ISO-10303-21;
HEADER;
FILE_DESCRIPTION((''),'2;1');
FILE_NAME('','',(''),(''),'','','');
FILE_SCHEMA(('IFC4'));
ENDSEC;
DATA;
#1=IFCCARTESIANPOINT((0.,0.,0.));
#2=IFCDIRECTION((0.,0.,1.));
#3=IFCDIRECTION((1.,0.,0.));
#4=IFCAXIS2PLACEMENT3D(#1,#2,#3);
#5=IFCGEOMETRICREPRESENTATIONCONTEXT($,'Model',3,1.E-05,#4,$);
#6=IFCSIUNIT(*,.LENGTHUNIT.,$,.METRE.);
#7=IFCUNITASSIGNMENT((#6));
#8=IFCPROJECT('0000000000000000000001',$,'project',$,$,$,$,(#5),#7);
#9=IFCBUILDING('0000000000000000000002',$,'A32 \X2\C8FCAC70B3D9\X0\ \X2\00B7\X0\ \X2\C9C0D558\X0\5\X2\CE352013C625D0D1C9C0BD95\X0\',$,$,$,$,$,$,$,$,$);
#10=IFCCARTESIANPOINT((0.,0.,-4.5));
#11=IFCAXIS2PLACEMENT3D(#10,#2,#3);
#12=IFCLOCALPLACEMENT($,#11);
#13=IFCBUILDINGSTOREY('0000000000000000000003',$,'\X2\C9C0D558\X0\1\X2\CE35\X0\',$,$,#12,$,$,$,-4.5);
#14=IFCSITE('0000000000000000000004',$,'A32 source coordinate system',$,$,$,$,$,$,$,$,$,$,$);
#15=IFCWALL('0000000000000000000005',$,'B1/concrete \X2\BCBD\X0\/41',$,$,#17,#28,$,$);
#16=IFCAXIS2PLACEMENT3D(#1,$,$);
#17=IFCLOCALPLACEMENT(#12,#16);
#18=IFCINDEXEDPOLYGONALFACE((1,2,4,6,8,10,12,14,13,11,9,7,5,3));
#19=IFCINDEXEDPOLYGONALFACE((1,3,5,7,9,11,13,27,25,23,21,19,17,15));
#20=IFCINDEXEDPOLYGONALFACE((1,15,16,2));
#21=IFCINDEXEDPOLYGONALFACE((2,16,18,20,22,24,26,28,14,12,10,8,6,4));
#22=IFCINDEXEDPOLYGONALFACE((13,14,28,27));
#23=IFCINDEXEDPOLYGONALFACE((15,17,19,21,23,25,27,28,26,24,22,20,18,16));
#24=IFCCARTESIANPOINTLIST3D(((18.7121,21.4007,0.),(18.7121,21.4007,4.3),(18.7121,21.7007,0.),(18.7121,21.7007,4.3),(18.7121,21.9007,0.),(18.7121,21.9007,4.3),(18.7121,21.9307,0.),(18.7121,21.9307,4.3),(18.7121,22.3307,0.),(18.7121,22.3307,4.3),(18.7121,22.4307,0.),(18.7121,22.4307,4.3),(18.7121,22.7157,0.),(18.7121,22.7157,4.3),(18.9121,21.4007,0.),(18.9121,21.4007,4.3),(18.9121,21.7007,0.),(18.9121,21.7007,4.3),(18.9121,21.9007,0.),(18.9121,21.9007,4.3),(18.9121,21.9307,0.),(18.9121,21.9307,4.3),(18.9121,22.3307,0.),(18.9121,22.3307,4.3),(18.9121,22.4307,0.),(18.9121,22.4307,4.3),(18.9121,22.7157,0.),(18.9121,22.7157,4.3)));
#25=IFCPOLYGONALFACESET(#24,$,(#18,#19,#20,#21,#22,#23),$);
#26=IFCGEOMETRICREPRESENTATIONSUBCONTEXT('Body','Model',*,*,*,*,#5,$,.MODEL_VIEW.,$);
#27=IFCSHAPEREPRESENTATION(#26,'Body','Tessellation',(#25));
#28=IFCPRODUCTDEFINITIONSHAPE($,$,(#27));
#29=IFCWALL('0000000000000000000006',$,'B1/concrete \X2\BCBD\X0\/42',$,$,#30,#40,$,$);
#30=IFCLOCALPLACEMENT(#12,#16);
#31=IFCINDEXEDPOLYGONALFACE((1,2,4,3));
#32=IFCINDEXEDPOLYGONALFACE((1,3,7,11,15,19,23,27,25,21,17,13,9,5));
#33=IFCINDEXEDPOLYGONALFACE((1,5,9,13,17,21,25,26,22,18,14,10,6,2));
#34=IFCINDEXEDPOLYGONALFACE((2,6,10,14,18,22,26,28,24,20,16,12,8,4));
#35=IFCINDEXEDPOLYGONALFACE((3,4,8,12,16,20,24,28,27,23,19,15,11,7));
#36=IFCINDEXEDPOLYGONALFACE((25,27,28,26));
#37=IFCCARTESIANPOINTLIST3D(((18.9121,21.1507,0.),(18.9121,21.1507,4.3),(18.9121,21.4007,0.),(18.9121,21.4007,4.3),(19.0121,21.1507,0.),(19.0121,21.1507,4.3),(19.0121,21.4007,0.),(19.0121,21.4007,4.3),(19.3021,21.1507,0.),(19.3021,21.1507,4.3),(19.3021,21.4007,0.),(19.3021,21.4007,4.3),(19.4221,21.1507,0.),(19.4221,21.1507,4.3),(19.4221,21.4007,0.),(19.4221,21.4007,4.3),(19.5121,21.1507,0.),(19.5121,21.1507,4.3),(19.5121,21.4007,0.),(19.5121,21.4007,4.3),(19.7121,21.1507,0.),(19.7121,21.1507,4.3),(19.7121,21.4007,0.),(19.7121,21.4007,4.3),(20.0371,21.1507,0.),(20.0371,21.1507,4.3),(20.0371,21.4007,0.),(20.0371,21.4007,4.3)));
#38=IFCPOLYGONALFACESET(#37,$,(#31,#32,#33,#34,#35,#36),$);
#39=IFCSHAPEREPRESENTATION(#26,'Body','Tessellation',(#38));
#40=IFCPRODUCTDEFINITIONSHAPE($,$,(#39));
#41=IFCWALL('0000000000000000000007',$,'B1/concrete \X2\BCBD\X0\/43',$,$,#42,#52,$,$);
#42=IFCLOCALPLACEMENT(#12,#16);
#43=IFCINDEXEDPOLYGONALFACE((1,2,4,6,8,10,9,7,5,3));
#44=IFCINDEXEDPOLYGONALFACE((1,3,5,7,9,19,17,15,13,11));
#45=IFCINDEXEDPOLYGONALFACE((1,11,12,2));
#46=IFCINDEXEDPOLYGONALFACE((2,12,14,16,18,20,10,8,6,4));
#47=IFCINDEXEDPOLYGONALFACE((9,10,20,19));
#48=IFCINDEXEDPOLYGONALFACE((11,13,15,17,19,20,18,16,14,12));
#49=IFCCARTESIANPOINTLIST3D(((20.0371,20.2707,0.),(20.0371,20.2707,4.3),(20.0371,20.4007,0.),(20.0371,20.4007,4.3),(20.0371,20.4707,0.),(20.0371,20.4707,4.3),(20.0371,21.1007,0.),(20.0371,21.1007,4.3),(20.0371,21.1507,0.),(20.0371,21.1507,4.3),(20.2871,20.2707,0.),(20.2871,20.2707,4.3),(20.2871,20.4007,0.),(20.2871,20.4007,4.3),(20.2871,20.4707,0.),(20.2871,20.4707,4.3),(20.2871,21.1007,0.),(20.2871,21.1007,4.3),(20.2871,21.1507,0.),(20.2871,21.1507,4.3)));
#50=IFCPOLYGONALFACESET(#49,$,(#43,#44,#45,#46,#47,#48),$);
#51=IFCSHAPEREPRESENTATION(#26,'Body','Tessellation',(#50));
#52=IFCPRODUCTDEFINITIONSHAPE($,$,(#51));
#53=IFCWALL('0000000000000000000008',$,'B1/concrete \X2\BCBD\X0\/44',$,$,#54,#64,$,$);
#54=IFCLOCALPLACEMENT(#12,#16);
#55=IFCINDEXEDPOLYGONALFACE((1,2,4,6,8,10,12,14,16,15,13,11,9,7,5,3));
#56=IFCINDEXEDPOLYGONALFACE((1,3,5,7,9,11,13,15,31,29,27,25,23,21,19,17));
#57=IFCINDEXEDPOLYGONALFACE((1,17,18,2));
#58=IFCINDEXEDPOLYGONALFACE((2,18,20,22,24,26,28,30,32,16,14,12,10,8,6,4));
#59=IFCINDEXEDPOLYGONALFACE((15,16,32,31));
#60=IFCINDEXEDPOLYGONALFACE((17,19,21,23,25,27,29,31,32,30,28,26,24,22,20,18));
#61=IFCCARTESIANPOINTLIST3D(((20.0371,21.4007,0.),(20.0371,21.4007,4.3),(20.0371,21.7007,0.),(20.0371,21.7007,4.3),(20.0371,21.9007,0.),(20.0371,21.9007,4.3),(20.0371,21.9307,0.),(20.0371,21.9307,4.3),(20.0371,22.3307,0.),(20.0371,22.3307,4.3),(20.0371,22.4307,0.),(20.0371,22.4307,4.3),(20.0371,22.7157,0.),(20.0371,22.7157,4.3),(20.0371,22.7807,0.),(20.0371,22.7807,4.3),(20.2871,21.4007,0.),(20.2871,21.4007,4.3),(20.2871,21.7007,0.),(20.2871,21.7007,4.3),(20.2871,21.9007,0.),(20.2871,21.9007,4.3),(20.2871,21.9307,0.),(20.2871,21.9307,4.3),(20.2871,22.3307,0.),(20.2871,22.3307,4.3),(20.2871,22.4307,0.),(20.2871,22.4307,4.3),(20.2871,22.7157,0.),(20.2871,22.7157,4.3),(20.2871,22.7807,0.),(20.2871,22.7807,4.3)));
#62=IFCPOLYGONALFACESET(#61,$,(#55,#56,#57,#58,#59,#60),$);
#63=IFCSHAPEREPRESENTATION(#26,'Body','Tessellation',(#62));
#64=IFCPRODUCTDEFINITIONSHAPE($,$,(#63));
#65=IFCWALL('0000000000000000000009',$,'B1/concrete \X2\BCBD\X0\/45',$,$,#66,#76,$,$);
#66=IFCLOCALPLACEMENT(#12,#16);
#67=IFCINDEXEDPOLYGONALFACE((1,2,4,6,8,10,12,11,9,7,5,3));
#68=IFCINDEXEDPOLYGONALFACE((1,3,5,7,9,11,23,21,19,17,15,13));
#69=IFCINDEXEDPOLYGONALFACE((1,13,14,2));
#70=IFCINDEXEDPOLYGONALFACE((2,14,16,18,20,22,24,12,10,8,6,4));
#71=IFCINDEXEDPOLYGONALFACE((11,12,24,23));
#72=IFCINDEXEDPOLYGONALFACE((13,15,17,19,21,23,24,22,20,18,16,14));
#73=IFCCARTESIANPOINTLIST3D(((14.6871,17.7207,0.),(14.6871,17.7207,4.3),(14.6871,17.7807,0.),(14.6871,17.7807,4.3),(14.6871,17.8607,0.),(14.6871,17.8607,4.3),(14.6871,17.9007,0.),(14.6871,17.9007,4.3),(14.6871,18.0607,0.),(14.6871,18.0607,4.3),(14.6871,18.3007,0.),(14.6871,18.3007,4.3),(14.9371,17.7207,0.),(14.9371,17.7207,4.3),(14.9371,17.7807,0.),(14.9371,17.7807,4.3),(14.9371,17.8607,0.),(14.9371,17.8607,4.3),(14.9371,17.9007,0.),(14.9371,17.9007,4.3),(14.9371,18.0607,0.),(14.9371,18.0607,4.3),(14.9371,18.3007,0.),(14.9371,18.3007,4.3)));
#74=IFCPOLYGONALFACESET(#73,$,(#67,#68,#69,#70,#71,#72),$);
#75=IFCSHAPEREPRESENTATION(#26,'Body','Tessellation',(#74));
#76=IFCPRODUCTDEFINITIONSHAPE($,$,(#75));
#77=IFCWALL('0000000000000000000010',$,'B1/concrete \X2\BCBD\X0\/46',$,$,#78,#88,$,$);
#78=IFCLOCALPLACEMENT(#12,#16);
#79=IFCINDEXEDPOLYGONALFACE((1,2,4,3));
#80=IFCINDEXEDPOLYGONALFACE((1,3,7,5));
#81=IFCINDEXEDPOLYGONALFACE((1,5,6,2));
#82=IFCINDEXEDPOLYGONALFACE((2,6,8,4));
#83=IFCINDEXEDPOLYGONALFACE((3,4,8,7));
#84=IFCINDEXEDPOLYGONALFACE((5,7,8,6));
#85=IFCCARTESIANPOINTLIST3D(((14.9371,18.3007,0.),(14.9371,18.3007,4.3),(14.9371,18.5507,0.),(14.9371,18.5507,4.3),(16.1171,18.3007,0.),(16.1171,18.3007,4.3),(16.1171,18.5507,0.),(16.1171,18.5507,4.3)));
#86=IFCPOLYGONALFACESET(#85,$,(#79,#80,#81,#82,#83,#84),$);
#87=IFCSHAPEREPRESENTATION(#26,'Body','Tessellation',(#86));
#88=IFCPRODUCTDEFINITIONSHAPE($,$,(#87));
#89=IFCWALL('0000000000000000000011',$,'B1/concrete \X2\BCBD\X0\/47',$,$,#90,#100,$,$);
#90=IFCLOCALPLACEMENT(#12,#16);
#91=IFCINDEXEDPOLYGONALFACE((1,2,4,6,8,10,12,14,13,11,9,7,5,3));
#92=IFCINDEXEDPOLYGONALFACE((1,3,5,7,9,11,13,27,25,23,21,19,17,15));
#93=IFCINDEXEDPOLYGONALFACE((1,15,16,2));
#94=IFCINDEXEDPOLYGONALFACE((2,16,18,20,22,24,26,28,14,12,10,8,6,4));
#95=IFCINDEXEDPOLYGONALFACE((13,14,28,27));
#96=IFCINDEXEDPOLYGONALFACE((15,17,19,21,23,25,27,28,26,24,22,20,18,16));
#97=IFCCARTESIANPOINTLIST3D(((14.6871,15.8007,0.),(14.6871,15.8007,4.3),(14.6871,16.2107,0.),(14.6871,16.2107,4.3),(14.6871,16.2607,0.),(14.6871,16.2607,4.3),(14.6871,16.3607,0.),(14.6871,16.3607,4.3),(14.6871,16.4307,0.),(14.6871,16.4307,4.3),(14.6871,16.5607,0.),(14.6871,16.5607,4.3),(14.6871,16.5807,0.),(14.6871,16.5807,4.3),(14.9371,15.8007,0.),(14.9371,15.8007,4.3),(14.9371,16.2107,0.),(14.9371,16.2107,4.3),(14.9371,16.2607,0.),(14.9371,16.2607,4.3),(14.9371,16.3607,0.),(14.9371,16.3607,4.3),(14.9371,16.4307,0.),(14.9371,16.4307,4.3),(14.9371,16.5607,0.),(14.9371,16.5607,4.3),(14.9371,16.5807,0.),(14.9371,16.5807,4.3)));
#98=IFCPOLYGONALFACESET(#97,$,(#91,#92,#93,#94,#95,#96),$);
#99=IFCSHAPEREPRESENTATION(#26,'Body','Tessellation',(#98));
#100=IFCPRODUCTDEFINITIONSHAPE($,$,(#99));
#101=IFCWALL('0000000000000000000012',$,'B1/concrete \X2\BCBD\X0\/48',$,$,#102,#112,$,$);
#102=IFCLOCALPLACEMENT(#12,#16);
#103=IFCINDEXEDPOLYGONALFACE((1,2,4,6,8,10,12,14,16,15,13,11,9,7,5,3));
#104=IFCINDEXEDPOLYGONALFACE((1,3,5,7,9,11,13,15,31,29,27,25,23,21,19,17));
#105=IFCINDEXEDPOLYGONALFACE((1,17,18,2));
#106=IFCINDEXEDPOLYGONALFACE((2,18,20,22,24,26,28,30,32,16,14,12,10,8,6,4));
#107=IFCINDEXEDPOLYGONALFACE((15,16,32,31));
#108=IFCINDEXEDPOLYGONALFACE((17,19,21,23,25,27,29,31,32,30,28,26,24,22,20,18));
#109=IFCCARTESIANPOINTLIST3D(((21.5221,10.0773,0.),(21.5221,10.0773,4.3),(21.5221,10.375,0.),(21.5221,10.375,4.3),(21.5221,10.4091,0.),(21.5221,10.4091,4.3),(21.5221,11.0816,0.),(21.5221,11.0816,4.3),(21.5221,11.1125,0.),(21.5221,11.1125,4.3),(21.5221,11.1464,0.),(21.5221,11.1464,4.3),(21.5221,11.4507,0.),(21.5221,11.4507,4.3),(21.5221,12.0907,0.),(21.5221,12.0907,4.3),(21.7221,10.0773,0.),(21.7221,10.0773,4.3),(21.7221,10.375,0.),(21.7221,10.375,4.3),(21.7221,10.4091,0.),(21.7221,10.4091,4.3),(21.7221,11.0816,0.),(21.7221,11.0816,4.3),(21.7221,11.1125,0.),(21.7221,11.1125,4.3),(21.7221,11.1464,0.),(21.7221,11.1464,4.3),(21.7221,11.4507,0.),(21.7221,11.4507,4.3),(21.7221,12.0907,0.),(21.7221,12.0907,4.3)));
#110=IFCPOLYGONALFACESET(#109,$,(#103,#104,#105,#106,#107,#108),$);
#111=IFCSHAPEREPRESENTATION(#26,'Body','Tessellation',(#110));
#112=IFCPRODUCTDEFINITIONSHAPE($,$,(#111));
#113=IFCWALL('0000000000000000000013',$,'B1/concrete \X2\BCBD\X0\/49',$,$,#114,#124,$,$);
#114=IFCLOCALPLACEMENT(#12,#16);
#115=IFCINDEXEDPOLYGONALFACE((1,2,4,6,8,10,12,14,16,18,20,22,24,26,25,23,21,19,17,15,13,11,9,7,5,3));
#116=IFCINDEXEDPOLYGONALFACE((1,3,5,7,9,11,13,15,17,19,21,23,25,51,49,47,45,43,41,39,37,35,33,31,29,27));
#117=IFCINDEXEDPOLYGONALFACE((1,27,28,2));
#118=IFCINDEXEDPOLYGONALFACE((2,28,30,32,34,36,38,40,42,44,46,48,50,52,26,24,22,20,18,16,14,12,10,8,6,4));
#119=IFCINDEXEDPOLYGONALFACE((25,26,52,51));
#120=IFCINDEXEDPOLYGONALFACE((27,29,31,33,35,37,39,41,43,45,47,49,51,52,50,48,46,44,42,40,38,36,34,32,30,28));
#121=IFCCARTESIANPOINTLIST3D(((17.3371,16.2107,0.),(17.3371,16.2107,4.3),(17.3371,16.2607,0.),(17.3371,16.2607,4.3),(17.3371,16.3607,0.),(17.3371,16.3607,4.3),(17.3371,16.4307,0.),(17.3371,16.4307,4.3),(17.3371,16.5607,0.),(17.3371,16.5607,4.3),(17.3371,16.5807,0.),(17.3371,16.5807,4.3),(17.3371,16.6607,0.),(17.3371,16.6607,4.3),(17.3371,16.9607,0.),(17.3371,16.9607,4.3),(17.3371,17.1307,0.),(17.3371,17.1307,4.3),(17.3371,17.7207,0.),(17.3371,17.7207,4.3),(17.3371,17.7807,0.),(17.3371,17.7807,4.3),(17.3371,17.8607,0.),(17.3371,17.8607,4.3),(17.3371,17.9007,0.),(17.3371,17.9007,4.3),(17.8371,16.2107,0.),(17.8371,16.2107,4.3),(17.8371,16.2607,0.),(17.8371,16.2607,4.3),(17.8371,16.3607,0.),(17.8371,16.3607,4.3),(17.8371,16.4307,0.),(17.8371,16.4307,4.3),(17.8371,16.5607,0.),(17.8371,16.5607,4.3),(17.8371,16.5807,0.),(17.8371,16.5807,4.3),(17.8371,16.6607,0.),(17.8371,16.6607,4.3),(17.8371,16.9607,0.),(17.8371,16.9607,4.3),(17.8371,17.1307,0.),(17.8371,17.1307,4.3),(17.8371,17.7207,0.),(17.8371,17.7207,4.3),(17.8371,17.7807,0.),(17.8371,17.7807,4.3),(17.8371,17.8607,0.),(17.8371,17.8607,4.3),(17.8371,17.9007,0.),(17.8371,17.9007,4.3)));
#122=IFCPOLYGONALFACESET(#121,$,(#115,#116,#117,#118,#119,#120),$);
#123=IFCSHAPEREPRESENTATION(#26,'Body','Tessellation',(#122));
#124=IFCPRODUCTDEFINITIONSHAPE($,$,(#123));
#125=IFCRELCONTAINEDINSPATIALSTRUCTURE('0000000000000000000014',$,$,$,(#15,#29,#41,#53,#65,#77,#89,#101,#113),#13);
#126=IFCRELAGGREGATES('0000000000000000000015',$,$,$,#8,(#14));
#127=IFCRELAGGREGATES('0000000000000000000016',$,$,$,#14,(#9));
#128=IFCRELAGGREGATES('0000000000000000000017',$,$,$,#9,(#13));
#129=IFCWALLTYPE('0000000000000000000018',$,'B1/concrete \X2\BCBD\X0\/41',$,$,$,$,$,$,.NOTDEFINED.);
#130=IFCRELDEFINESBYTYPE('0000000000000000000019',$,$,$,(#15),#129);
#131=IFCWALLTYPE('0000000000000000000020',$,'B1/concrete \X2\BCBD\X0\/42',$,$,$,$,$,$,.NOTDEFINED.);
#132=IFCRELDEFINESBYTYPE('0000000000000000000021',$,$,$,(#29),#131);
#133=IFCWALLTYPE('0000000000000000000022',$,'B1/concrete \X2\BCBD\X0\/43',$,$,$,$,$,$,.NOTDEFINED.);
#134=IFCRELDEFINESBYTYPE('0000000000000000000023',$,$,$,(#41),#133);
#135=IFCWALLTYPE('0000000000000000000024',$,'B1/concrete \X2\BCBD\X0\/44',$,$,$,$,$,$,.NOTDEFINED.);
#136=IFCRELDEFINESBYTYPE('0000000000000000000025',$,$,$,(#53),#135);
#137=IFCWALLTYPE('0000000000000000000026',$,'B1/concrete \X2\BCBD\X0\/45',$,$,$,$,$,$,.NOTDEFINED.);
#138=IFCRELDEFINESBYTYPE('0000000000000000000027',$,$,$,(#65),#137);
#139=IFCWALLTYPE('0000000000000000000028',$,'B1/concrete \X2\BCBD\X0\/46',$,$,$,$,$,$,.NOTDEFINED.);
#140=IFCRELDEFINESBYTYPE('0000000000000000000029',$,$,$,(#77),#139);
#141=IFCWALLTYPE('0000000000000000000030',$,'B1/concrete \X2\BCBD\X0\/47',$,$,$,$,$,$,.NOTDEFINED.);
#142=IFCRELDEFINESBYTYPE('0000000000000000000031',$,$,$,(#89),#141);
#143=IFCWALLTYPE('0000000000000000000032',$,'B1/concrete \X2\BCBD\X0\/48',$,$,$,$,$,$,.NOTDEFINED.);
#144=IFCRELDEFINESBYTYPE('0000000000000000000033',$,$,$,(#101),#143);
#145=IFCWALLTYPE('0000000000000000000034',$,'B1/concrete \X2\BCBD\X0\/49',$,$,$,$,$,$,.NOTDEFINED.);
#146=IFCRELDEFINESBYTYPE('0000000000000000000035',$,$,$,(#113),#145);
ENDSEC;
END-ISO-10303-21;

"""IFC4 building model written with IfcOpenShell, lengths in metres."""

from ifc_helpers import new_model, si_unit, frame, origin, origin_with_axes, place, context, subcontext, project, spatial, polyline, outline, extrude, source, transform, mapped, type_object, type_shapes, element, save


model = new_model("IFC4")

# Units and contexts
model_context = context("Model", 3, precision=1e-05, world=origin_with_axes())
body_context = subcontext(model_context, "Body", "Model", "MODEL_VIEW")
ifc_project = project(units=[si_unit("LENGTHUNIT", "METRE")], contexts=[model_context])

# Site, building, storey
site = spatial("IfcSite", under=ifc_project, Name="A32 source coordinate system")
building = spatial("IfcBuilding", under=site, Name="A32 주거동 · 지하5층–옥탑지붕")
storey_placement = place(None, frame((0.0, 0.0, -4.5), z_axis=(0.0, 0.0, 1.0), x_axis=(1.0, 0.0, 0.0)))
storey = spatial("IfcBuildingStorey", under=building, at=storey_placement, Name="지하1층", Elevation=-4.5)

# Walls
wall_type_1 = type_object("IfcWallType", Name="B1/concrete 벽/41", PredefinedType="NOTDEFINED")
shared_shape_1 = source(origin(), body_context, "Body", "SweptSolid", [
    extrude(outline(polyline([(18.7121, 21.9307), (18.7121, 22.3307), (18.7121, 22.4307), (18.7121, 22.7157), (18.9121, 22.7157), (18.9121, 22.4307), (18.9121, 22.3307), (18.9121, 21.9307), (18.9121, 21.9007), (18.9121, 21.7007), (18.9121, 21.4007), (18.7121, 21.4007), (18.7121, 21.7007), (18.7121, 21.9007), (18.7121, 21.9307)])), origin(), (0.0, 0.0, 1.0), 4.3),
])
type_shapes(wall_type_1, [shared_shape_1])
wall_1_placement = place(storey_placement, origin_with_axes())
element("IfcWall", 1, at=wall_1_placement, inside=storey, type_object=wall_type_1, Name="B1/concrete 벽/41", context=body_context, shape_type="MappedRepresentation", body=[
    mapped(shared_shape_1, transform((0.0, 0.0, 0.0), scale=1.0)),
])
wall_type_2 = type_object("IfcWallType", Name="B1/concrete 벽/42", PredefinedType="NOTDEFINED")
shared_shape_2 = source(origin(), body_context, "Body", "SweptSolid", [
    extrude(outline(polyline([(19.4221, 21.4007), (19.5121, 21.4007), (19.7121, 21.4007), (20.0371, 21.4007), (20.0371, 21.1507), (19.7121, 21.1507), (19.5121, 21.1507), (19.4221, 21.1507), (19.3021, 21.1507), (19.0121, 21.1507), (18.9121, 21.1507), (18.9121, 21.4007), (19.0121, 21.4007), (19.3021, 21.4007), (19.4221, 21.4007)])), origin(), (0.0, 0.0, 1.0), 4.3),
])
type_shapes(wall_type_2, [shared_shape_2])
wall_2_placement = place(storey_placement, origin_with_axes())
element("IfcWall", 2, at=wall_2_placement, inside=storey, type_object=wall_type_2, Name="B1/concrete 벽/42", context=body_context, shape_type="MappedRepresentation", body=[
    mapped(shared_shape_2, transform((0.0, 0.0, 0.0), scale=1.0)),
])
wall_type_3 = type_object("IfcWallType", Name="B1/concrete 벽/43", PredefinedType="NOTDEFINED")
shared_shape_3 = source(origin(), body_context, "Body", "SweptSolid", [
    extrude(outline(polyline([(20.2871, 20.4707), (20.2871, 20.4007), (20.2871, 20.2707), (20.0371, 20.2707), (20.0371, 20.4007), (20.0371, 20.4707), (20.0371, 21.1007), (20.0371, 21.1507), (20.2871, 21.1507), (20.2871, 21.1007), (20.2871, 20.4707)])), origin(), (0.0, 0.0, 1.0), 4.3),
])
type_shapes(wall_type_3, [shared_shape_3])
wall_3_placement = place(storey_placement, origin_with_axes())
element("IfcWall", 3, at=wall_3_placement, inside=storey, type_object=wall_type_3, Name="B1/concrete 벽/43", context=body_context, shape_type="MappedRepresentation", body=[
    mapped(shared_shape_3, transform((0.0, 0.0, 0.0), scale=1.0)),
])
wall_type_4 = type_object("IfcWallType", Name="B1/concrete 벽/44", PredefinedType="NOTDEFINED")
shared_shape_4 = source(origin(), body_context, "Body", "SweptSolid", [
    extrude(outline(polyline([(20.0371, 21.9307), (20.0371, 22.3307), (20.0371, 22.4307), (20.0371, 22.7157), (20.0371, 22.7807), (20.2871, 22.7807), (20.2871, 22.7157), (20.2871, 22.4307), (20.2871, 22.3307), (20.2871, 21.9307), (20.2871, 21.9007), (20.2871, 21.7007), (20.2871, 21.4007), (20.0371, 21.4007), (20.0371, 21.7007), (20.0371, 21.9007), (20.0371, 21.9307)])), origin(), (0.0, 0.0, 1.0), 4.3),
])
type_shapes(wall_type_4, [shared_shape_4])
wall_4_placement = place(storey_placement, origin_with_axes())
element("IfcWall", 4, at=wall_4_placement, inside=storey, type_object=wall_type_4, Name="B1/concrete 벽/44", context=body_context, shape_type="MappedRepresentation", body=[
    mapped(shared_shape_4, transform((0.0, 0.0, 0.0), scale=1.0)),
])
wall_type_5 = type_object("IfcWallType", Name="B1/concrete 벽/45", PredefinedType="NOTDEFINED")
shared_shape_5 = source(origin(), body_context, "Body", "SweptSolid", [
    extrude(outline(polyline([(14.9371, 17.9007), (14.9371, 17.8607), (14.9371, 17.7807), (14.9371, 17.7207), (14.6871, 17.7207), (14.6871, 17.7807), (14.6871, 17.8607), (14.6871, 17.9007), (14.6871, 18.0607), (14.6871, 18.3007), (14.9371, 18.3007), (14.9371, 18.0607), (14.9371, 17.9007)])), origin(), (0.0, 0.0, 1.0), 4.3),
])
type_shapes(wall_type_5, [shared_shape_5])
wall_5_placement = place(storey_placement, origin_with_axes())
element("IfcWall", 5, at=wall_5_placement, inside=storey, type_object=wall_type_5, Name="B1/concrete 벽/45", context=body_context, shape_type="MappedRepresentation", body=[
    mapped(shared_shape_5, transform((0.0, 0.0, 0.0), scale=1.0)),
])
wall_type_6 = type_object("IfcWallType", Name="B1/concrete 벽/46", PredefinedType="NOTDEFINED")
shared_shape_6 = source(origin(), body_context, "Body", "SweptSolid", [
    extrude(outline(polyline([(16.1171, 18.3007), (14.9371, 18.3007), (14.9371, 18.5507), (16.1171, 18.5507), (16.1171, 18.3007)])), origin(), (0.0, 0.0, 1.0), 4.3),
])
type_shapes(wall_type_6, [shared_shape_6])
wall_6_placement = place(storey_placement, origin_with_axes())
element("IfcWall", 6, at=wall_6_placement, inside=storey, type_object=wall_type_6, Name="B1/concrete 벽/46", context=body_context, shape_type="MappedRepresentation", body=[
    mapped(shared_shape_6, transform((0.0, 0.0, 0.0), scale=1.0)),
])
wall_type_7 = type_object("IfcWallType", Name="B1/concrete 벽/47", PredefinedType="NOTDEFINED")
shared_shape_7 = source(origin(), body_context, "Body", "SweptSolid", [
    extrude(outline(polyline([(14.6871, 16.3607), (14.6871, 16.4307), (14.6871, 16.5607), (14.6871, 16.5807), (14.9371, 16.5807), (14.9371, 16.5607), (14.9371, 16.4307), (14.9371, 16.3607), (14.9371, 16.2607), (14.9371, 16.2107), (14.9371, 15.8007), (14.6871, 15.8007), (14.6871, 16.2107), (14.6871, 16.2607), (14.6871, 16.3607)])), origin(), (0.0, 0.0, 1.0), 4.3),
])
type_shapes(wall_type_7, [shared_shape_7])
wall_7_placement = place(storey_placement, origin_with_axes())
element("IfcWall", 7, at=wall_7_placement, inside=storey, type_object=wall_type_7, Name="B1/concrete 벽/47", context=body_context, shape_type="MappedRepresentation", body=[
    mapped(shared_shape_7, transform((0.0, 0.0, 0.0), scale=1.0)),
])
wall_type_8 = type_object("IfcWallType", Name="B1/concrete 벽/48", PredefinedType="NOTDEFINED")
shared_shape_8 = source(origin(), body_context, "Body", "SweptSolid", [
    extrude(outline(polyline([(21.7221, 11.1125), (21.7221, 11.0816), (21.7221, 10.4091), (21.7221, 10.375), (21.7221, 10.0773), (21.5221, 10.0773), (21.5221, 10.375), (21.5221, 10.4091), (21.5221, 11.0816), (21.5221, 11.1125), (21.5221, 11.1464), (21.5221, 11.4507), (21.5221, 12.0907), (21.7221, 12.0907), (21.7221, 11.4507), (21.7221, 11.1464), (21.7221, 11.1125)])), origin(), (0.0, 0.0, 1.0), 4.3),
])
type_shapes(wall_type_8, [shared_shape_8])
wall_8_placement = place(storey_placement, origin_with_axes())
element("IfcWall", 8, at=wall_8_placement, inside=storey, type_object=wall_type_8, Name="B1/concrete 벽/48", context=body_context, shape_type="MappedRepresentation", body=[
    mapped(shared_shape_8, transform((0.0, 0.0, 0.0), scale=1.0)),
])
wall_type_9 = type_object("IfcWallType", Name="B1/concrete 벽/49", PredefinedType="NOTDEFINED")
shared_shape_9 = source(origin(), body_context, "Body", "SweptSolid", [
    extrude(outline(polyline([(17.3371, 16.9607), (17.3371, 17.1307), (17.3371, 17.7207), (17.3371, 17.7807), (17.3371, 17.8607), (17.3371, 17.9007), (17.8371, 17.9007), (17.8371, 17.8607), (17.8371, 17.7807), (17.8371, 17.7207), (17.8371, 17.1307), (17.8371, 16.9607), (17.8371, 16.6607), (17.8371, 16.5807), (17.8371, 16.5607), (17.8371, 16.4307), (17.8371, 16.3607), (17.8371, 16.2607), (17.8371, 16.2107), (17.3371, 16.2107), (17.3371, 16.2607), (17.3371, 16.3607), (17.3371, 16.4307), (17.3371, 16.5607), (17.3371, 16.5807), (17.3371, 16.6607), (17.3371, 16.9607)])), origin(), (0.0, 0.0, 1.0), 4.3),
])
type_shapes(wall_type_9, [shared_shape_9])
wall_9_placement = place(storey_placement, origin_with_axes())
element("IfcWall", 9, at=wall_9_placement, inside=storey, type_object=wall_type_9, Name="B1/concrete 벽/49", context=body_context, shape_type="MappedRepresentation", body=[
    mapped(shared_shape_9, transform((0.0, 0.0, 0.0), scale=1.0)),
])

save(model, "model.ifc")
